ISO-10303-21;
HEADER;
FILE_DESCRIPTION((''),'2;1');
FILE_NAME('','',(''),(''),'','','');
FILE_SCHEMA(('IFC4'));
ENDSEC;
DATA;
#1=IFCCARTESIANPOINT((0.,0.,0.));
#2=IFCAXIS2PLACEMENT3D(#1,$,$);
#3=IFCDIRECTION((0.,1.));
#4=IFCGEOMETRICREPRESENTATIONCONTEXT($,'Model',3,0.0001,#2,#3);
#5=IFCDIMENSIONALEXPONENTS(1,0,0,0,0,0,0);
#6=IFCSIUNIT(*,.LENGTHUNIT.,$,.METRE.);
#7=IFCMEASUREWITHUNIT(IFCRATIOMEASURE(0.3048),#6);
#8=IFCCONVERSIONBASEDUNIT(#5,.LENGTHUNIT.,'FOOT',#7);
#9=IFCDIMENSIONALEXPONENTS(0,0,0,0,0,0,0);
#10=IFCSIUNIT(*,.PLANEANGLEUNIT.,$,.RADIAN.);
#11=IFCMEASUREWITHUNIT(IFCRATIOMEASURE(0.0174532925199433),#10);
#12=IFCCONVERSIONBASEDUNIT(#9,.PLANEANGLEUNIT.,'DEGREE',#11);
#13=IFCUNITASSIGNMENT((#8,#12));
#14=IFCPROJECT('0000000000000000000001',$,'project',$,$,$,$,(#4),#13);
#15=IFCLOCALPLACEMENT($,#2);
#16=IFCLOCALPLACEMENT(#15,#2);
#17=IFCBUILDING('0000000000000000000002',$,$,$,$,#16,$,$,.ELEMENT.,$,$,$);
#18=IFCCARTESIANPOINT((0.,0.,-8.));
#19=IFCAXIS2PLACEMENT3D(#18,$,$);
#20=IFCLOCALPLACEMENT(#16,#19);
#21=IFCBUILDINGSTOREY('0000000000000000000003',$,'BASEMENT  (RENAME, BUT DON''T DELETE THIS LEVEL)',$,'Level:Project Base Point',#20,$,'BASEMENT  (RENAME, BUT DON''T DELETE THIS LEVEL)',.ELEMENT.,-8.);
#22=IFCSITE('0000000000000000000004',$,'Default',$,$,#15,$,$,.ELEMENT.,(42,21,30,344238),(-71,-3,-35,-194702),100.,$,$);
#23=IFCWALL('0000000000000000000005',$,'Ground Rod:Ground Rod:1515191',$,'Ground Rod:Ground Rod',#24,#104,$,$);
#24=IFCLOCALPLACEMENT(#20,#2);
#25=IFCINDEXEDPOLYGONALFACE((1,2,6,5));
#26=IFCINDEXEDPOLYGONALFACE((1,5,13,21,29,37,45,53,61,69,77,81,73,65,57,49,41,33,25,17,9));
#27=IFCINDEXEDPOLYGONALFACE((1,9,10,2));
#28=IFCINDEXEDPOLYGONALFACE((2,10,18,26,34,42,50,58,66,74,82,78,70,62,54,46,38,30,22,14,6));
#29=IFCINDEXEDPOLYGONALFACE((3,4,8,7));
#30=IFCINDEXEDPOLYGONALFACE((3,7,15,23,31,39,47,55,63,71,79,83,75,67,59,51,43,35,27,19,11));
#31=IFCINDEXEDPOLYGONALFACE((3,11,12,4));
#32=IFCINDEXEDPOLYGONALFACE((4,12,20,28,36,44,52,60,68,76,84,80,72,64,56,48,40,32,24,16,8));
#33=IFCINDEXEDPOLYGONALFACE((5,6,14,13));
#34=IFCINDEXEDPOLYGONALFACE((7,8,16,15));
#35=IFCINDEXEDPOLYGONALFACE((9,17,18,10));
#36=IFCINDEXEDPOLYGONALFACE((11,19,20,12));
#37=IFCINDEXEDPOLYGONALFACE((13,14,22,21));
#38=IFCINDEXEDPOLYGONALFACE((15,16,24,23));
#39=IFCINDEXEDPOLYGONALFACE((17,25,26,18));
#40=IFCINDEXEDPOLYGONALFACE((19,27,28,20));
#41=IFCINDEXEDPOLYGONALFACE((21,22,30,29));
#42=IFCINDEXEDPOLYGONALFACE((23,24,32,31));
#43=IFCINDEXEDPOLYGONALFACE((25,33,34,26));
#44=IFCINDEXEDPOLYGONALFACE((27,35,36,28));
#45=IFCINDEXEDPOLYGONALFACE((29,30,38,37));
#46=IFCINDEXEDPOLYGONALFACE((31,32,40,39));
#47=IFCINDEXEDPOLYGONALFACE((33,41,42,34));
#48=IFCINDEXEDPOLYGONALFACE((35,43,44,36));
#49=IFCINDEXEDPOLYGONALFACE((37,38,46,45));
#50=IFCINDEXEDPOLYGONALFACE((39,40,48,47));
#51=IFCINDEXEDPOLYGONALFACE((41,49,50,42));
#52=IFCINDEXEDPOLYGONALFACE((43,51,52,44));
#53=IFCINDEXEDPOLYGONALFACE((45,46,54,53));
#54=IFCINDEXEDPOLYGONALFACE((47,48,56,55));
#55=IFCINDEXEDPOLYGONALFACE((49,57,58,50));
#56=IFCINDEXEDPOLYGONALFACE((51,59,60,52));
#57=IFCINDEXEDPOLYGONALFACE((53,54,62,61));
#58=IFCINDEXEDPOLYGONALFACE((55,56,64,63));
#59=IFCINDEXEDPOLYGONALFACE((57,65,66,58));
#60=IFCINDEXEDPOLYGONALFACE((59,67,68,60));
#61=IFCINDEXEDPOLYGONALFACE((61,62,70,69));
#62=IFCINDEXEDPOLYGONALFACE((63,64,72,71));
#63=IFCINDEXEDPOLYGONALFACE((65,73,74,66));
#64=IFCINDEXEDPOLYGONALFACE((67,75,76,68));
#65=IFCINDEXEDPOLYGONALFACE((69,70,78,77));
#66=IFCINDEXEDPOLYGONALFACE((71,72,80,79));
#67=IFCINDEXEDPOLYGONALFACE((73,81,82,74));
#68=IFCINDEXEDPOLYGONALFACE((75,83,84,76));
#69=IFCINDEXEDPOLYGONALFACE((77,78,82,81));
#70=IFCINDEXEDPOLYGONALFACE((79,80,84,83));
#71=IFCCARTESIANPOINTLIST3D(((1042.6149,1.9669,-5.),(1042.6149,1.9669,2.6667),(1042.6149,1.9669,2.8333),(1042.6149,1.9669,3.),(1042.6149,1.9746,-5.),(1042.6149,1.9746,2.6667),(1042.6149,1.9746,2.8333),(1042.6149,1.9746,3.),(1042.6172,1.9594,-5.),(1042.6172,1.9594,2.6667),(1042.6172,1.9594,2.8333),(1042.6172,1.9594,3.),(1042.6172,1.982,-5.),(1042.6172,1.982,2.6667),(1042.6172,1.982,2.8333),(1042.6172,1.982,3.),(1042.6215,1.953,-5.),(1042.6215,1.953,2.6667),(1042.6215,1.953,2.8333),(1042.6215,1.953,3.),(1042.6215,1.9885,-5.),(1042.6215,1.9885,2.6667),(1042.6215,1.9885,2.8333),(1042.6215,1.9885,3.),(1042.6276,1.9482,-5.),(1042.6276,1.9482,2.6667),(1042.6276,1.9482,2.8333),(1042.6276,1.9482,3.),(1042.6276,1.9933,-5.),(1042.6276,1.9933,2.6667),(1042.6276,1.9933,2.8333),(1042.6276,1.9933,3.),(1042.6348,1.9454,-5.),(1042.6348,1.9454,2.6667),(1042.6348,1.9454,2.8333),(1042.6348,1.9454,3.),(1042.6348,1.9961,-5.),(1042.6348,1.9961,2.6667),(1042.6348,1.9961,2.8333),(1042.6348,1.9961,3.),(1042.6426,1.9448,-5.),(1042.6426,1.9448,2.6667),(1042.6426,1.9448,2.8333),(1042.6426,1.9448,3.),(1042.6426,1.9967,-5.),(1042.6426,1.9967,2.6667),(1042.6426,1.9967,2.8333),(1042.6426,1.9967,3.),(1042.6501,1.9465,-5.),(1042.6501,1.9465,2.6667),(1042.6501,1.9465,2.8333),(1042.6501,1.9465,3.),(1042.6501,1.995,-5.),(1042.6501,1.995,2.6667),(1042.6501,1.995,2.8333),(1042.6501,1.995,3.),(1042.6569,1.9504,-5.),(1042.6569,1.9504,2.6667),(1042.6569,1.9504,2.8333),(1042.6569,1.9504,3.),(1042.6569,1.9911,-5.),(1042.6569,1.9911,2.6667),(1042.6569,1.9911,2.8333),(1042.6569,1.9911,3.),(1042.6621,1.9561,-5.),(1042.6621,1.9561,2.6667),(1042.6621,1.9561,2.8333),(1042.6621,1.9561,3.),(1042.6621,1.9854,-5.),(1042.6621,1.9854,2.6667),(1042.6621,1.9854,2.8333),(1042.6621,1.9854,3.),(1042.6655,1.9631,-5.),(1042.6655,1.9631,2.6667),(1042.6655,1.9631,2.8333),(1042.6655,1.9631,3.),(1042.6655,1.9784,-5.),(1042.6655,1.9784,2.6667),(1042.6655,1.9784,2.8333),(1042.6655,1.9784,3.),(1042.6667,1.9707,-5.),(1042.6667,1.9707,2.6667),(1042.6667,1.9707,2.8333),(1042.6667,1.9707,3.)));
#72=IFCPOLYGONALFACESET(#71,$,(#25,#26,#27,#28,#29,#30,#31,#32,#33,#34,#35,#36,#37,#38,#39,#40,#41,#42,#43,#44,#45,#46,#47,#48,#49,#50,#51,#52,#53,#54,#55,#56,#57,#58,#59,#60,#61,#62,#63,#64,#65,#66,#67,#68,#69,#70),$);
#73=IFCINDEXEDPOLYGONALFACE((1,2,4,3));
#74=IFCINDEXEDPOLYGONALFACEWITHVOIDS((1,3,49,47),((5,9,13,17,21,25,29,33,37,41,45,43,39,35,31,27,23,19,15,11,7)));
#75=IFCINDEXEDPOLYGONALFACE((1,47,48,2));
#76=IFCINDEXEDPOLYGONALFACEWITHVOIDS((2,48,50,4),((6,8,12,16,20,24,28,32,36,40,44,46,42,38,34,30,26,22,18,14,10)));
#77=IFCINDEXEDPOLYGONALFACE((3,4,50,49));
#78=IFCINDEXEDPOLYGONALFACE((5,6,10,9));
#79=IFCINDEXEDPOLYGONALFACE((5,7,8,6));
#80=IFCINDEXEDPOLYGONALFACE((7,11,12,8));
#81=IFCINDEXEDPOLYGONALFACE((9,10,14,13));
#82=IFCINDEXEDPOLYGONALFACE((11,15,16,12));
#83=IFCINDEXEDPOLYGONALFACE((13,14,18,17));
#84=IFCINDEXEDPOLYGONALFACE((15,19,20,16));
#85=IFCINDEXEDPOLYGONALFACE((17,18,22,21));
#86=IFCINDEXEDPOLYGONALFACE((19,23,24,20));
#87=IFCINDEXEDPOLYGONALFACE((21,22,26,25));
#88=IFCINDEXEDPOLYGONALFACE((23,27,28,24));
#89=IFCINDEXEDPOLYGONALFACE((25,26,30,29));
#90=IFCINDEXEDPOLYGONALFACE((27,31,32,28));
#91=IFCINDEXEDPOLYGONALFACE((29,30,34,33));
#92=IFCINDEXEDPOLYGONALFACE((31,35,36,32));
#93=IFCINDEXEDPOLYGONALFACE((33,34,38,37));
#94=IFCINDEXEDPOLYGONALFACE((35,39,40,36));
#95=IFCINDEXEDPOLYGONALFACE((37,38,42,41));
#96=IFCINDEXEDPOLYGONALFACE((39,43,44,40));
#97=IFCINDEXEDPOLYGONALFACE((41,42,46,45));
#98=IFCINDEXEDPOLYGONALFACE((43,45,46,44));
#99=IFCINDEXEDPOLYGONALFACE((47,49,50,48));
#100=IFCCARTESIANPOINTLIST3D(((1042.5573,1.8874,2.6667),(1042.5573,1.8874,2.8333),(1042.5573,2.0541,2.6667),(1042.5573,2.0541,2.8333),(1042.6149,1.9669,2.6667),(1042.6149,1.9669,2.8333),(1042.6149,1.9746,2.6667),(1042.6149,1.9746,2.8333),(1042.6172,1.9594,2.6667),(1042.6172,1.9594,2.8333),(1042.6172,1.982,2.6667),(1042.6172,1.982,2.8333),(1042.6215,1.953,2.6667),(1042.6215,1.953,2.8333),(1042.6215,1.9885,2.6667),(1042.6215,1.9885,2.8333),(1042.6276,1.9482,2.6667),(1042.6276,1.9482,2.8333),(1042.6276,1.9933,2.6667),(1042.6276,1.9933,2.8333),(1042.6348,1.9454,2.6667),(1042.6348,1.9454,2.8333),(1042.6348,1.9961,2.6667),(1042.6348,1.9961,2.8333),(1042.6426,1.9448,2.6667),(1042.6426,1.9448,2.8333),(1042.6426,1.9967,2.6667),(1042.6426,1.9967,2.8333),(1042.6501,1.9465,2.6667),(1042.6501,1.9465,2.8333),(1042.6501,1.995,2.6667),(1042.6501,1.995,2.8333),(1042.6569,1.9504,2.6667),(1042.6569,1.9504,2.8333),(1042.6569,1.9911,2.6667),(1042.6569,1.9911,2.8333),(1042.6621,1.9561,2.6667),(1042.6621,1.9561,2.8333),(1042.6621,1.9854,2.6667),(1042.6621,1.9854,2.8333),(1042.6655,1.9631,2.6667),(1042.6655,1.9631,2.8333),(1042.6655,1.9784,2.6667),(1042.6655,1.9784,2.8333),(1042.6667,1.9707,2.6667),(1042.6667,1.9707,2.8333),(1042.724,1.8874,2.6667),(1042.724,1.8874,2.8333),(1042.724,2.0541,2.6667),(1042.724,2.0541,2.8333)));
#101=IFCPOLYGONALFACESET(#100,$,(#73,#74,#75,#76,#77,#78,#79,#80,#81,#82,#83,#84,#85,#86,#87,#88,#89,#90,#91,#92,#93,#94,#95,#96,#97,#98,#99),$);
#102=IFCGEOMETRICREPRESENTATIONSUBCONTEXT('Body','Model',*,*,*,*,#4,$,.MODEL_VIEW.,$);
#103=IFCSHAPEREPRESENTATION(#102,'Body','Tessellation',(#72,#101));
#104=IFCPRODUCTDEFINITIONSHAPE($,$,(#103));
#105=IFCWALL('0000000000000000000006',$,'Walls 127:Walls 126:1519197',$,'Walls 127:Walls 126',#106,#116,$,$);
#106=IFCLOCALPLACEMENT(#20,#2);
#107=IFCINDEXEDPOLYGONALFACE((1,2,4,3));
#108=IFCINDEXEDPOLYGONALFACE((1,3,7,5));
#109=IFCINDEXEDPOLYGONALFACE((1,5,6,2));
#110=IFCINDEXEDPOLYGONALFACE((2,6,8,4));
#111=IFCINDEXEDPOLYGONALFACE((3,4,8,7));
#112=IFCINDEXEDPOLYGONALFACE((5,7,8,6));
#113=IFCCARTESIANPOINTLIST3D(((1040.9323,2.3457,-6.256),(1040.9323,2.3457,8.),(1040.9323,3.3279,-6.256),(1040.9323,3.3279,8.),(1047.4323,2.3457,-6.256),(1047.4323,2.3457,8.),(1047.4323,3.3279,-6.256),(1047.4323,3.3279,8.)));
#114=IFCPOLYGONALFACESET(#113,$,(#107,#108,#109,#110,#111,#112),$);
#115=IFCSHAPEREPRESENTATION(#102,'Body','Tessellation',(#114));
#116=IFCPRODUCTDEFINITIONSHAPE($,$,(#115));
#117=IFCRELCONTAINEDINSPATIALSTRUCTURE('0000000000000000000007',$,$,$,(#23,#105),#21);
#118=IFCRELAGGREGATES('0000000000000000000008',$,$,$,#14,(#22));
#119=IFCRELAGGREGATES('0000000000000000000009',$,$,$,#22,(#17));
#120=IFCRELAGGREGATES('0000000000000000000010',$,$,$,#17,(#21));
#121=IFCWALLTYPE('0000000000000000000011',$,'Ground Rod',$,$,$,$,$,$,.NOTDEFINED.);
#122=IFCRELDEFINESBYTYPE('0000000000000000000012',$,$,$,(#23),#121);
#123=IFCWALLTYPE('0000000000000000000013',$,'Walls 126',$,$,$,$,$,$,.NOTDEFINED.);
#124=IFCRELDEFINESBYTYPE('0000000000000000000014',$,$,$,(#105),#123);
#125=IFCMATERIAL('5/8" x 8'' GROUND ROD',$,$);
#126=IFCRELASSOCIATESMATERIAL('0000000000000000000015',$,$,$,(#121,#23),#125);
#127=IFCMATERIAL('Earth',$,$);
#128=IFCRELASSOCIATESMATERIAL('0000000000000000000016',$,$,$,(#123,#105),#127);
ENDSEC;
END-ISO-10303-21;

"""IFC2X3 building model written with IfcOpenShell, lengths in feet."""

from ifc_helpers import new_model, entity, si_unit, converted_unit, direction, frame, frame_2d, origin, origin_2d_with_axis, place, context, subcontext, project, spatial, rectangle, circle, extrude, material, type_object, element, save


model = new_model("IFC2X3")

# Units and contexts
model_context = context("Model", 3, precision=0.0001, world=origin(), true_north=direction((0.0, 1.0)))
body_context = subcontext(model_context, "Body", "Model", "MODEL_VIEW")
ifc_project = project(units=[converted_unit("LENGTHUNIT", "FOOT", entity("IfcRatioMeasure", 0.3048), si_unit("LENGTHUNIT", "METRE"), dimensions=[1, 0, 0, 0, 0, 0, 0]), converted_unit("PLANEANGLEUNIT", "DEGREE", entity("IfcRatioMeasure", 0.0174532925199433), si_unit("PLANEANGLEUNIT", "RADIAN"), dimensions=[0, 0, 0, 0, 0, 0, 0])], contexts=[model_context])

# Site, building, storey
site_placement = place(None, origin())
site = spatial("IfcSite", under=ifc_project, at=site_placement, Name="Default", CompositionType="ELEMENT", RefLatitude=(42, 21, 30, 344238), RefLongitude=(-71, -3, -35, -194702), RefElevation=100.0)
building_placement = place(site_placement, origin())
building = spatial("IfcBuilding", under=site, at=building_placement, CompositionType="ELEMENT")
storey_placement = place(building_placement, frame((0.0, 0.0, -8.0)))
storey = spatial("IfcBuildingStorey", under=building, at=storey_placement, Name="BASEMENT  (RENAME, BUT DON'T DELETE THIS LEVEL)", ObjectType="Level:Project Base Point", LongName="BASEMENT  (RENAME, BUT DON'T DELETE THIS LEVEL)", CompositionType="ELEMENT", Elevation=-8.0)

# Wall, opening
ifc_material_1 = material(Name="5/8\" x 8' GROUND ROD")
wall_type_1 = type_object("IfcWallType", Name="Ground Rod", PredefinedType="NOTDEFINED", material=ifc_material_1)
wall_1_placement = place(storey_placement, frame((1042.5573, 1.8874, -5.0)))
wall_1 = element("IfcWall", 1, at=wall_1_placement, inside=storey, type_object=wall_type_1, material=ifc_material_1, Name="Ground Rod:Ground Rod:1515191", ObjectType="Ground Rod:Ground Rod", context=body_context, shape_type="SweptSolid", body=[
    extrude(circle(Radius=0.026, at=origin_2d_with_axis()), frame((0.0833, 0.0833, 0.0)), (0.0, 0.0, 1.0), 8.0),
    extrude(rectangle(XDim=0.1667, YDim=0.1667, at=frame_2d((0.0, 0.0), x_axis=(1.0, 0.0))), frame((0.0833, 0.0833, 7.6667), z_axis=(0.0, 0.0, 1.0), x_axis=(-1.0, 0.0, 0.0)), (0.0, 0.0, 1.0), 0.1667),
])
opening_placement = place(storey_placement, frame((1042.5573, 1.8874, -5.0)))
element("IfcOpeningElement", 2, at=opening_placement, cuts=wall_1, ObjectType="Opening", context=body_context, shape_type="SweptSolid", body=[
    extrude(circle(Radius=0.026, at=frame_2d((0.0, 0.0), x_axis=(1.0, 0.0))), frame((0.0833, 0.0833, 7.6667)), (0.0, 0.0, 1.0), 0.1667),
])

# Wall
ifc_material_2 = material(Name="Earth")
wall_type_2 = type_object("IfcWallType", Name="Walls 126", PredefinedType="NOTDEFINED", material=ifc_material_2)
wall_2_placement = place(storey_placement, frame((1040.9323, 2.3457, -6.256)))
element("IfcWall", 3, at=wall_2_placement, inside=storey, type_object=wall_type_2, material=ifc_material_2, Name="Walls 127:Walls 126:1519197", ObjectType="Walls 127:Walls 126", context=body_context, shape_type="SweptSolid", body=[
    extrude(rectangle(XDim=0.9821, YDim=6.5, at=frame_2d((0.0, 0.0), x_axis=(1.0, 0.0))), frame((3.25, 0.4911, 0.0), z_axis=(0.0, 0.0, 1.0), x_axis=(0.0, 1.0, 0.0)), (0.0, 0.0, 1.0), 14.256),
])

save(model, "model.ifc")
